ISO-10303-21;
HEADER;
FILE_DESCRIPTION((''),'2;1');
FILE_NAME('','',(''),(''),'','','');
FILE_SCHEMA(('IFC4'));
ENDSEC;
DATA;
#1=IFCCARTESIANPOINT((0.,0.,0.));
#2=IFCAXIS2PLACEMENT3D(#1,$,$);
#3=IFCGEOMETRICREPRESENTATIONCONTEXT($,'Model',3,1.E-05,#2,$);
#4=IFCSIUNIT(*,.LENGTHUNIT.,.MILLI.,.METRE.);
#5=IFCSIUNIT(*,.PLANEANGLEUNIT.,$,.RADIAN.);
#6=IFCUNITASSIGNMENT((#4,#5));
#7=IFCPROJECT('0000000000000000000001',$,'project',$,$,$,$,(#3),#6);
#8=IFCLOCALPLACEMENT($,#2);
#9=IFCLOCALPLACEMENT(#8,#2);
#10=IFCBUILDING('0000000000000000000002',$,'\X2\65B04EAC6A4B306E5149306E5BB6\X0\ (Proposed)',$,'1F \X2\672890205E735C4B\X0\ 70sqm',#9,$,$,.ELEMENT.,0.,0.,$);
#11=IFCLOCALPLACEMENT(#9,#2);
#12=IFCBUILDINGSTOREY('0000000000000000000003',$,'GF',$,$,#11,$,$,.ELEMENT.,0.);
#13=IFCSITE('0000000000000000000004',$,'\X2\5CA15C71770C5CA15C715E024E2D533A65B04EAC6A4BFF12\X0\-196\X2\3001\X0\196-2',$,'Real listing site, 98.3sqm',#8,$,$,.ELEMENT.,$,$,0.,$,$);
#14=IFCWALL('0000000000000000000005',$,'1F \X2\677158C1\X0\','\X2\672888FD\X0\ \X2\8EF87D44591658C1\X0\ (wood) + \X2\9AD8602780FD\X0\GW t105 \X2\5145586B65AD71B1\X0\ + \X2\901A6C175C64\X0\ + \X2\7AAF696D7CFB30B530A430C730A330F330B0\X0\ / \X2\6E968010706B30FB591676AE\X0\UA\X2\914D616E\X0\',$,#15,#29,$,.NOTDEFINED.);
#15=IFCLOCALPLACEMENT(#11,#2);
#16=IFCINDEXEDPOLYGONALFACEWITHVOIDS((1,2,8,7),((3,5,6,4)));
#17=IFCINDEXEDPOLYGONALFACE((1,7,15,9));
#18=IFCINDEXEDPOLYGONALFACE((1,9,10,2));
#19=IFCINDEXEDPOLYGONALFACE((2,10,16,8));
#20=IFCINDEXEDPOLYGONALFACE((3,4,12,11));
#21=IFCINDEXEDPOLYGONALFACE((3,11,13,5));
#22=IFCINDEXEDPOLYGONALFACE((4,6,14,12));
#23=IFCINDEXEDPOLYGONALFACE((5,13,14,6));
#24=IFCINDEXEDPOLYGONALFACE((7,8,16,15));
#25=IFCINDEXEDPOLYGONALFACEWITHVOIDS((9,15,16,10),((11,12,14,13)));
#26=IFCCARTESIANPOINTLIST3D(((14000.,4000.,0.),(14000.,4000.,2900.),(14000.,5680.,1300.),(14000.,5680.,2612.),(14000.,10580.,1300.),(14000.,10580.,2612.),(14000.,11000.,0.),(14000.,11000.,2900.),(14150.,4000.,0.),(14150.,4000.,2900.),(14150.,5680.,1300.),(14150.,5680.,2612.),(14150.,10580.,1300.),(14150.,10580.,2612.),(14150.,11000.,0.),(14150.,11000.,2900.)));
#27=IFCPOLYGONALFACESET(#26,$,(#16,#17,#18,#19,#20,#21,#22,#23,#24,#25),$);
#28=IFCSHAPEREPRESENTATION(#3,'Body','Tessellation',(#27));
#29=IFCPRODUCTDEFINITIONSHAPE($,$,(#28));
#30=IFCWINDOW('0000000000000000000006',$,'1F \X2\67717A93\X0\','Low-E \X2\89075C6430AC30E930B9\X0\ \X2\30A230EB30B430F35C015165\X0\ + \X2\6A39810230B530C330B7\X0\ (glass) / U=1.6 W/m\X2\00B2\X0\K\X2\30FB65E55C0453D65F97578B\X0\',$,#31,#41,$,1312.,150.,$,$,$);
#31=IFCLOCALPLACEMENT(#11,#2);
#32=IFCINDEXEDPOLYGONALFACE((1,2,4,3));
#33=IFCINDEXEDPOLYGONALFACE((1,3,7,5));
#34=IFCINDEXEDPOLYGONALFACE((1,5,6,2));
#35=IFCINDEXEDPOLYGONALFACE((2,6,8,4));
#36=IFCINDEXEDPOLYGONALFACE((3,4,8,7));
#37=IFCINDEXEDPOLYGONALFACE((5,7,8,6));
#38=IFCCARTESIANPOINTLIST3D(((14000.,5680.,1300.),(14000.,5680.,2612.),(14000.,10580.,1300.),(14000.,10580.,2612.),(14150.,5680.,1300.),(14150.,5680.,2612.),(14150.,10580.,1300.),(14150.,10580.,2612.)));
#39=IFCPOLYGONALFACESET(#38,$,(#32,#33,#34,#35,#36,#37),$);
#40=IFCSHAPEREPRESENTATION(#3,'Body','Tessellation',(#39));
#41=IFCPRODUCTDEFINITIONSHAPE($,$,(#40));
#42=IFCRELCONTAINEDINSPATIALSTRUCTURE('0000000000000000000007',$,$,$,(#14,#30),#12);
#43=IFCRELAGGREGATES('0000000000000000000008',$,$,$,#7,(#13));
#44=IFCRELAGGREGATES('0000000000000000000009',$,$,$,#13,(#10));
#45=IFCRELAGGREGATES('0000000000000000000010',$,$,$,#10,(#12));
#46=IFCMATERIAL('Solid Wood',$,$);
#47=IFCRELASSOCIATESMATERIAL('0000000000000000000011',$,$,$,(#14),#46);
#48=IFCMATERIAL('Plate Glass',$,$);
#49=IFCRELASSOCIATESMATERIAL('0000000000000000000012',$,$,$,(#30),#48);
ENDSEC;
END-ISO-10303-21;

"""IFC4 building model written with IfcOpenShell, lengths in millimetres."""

from ifc_helpers import new_model, si_unit, frame, frame_2d, origin, place, context, project, spatial, rectangle, extrude, material, element, fill, save


model = new_model("IFC4")

# Units and contexts
model_context = context("Model", 3, precision=1e-05, world=origin())
ifc_project = project(units=[si_unit("LENGTHUNIT", "METRE", prefix="MILLI"), si_unit("PLANEANGLEUNIT", "RADIAN")], contexts=[model_context])

# Site, building, storey
site_placement = place(None, origin())
site = spatial("IfcSite", under=ifc_project, at=site_placement, Name="岡山県岡山市中区新京橋２-196、196-2", ObjectType="Real listing site, 98.3sqm", CompositionType="ELEMENT", RefElevation=0.0)
building_placement = place(site_placement, origin())
building = spatial("IfcBuilding", under=site, at=building_placement, Name="新京橋の光の家 (Proposed)", ObjectType="1F 木造平屋 70sqm", CompositionType="ELEMENT", ElevationOfRefHeight=0.0, ElevationOfTerrain=0.0)
storey_placement = place(building_placement, origin())
storey = spatial("IfcBuildingStorey", under=building, at=storey_placement, Name="GF", CompositionType="ELEMENT", Elevation=0.0)

# Shared definitions
ifc_material_1 = material(Name="Solid Wood")

# Shared definitions
ifc_material_2 = material(Name="Plate Glass")

# Wall, opening, window
wall_1_placement = place(storey_placement, frame((7000.0, 2000.0, 0.0)))
wall_1 = element("IfcWall", 1, at=wall_1_placement, inside=storey, material=ifc_material_1, Name="1F 東壁", Description="木製 軸組外壁 (wood) + 高性能GW t105 充填断熱 + 通気層 + 窯業系サイディング / 準耐火・外皮UA配慮", PredefinedType="NOTDEFINED", context=model_context, shape_type="SweptSolid", body=[
    extrude(rectangle(XDim=150.0, YDim=7000.0, at=frame_2d((75.0, 3500.0))), frame((7000.0, 2000.0, 0.0)), (0.0, 0.0, 1.0), 2900.0),
])
opening_1_placement = place(storey_placement, frame((7000.0, 2840.0, 650.0)))
opening_1 = element("IfcOpeningElement", 2, at=opening_1_placement, cuts=wall_1, PredefinedType="NOTDEFINED", context=model_context, shape_type="SweptSolid", body=[
    extrude(rectangle(XDim=150.0, YDim=4900.0, at=frame_2d((75.0, 2450.0))), frame((7000.0, 2840.0, 650.0)), (0.0, 0.0, 1.0), 1312.0),
])
window_1_placement = place(storey_placement, frame((7000.0, 2840.0, 650.0)))
window_1 = element("IfcWindow", 3, at=window_1_placement, inside=storey, material=ifc_material_2, Name="1F 東窓", Description="Low-E 複層ガラス アルゴン封入 + 樹脂サッシ (glass) / U=1.6 W/m²K・日射取得型", OverallHeight=1312.0, OverallWidth=150.0, context=model_context, shape_type="SweptSolid", body=[
    extrude(rectangle(XDim=150.0, YDim=4900.0, at=frame_2d((75.0, 2450.0))), frame((7000.0, 2840.0, 650.0)), (0.0, 0.0, 1.0), 1312.0),
])
fill(opening_1, window_1)

save(model, "model.ifc")
